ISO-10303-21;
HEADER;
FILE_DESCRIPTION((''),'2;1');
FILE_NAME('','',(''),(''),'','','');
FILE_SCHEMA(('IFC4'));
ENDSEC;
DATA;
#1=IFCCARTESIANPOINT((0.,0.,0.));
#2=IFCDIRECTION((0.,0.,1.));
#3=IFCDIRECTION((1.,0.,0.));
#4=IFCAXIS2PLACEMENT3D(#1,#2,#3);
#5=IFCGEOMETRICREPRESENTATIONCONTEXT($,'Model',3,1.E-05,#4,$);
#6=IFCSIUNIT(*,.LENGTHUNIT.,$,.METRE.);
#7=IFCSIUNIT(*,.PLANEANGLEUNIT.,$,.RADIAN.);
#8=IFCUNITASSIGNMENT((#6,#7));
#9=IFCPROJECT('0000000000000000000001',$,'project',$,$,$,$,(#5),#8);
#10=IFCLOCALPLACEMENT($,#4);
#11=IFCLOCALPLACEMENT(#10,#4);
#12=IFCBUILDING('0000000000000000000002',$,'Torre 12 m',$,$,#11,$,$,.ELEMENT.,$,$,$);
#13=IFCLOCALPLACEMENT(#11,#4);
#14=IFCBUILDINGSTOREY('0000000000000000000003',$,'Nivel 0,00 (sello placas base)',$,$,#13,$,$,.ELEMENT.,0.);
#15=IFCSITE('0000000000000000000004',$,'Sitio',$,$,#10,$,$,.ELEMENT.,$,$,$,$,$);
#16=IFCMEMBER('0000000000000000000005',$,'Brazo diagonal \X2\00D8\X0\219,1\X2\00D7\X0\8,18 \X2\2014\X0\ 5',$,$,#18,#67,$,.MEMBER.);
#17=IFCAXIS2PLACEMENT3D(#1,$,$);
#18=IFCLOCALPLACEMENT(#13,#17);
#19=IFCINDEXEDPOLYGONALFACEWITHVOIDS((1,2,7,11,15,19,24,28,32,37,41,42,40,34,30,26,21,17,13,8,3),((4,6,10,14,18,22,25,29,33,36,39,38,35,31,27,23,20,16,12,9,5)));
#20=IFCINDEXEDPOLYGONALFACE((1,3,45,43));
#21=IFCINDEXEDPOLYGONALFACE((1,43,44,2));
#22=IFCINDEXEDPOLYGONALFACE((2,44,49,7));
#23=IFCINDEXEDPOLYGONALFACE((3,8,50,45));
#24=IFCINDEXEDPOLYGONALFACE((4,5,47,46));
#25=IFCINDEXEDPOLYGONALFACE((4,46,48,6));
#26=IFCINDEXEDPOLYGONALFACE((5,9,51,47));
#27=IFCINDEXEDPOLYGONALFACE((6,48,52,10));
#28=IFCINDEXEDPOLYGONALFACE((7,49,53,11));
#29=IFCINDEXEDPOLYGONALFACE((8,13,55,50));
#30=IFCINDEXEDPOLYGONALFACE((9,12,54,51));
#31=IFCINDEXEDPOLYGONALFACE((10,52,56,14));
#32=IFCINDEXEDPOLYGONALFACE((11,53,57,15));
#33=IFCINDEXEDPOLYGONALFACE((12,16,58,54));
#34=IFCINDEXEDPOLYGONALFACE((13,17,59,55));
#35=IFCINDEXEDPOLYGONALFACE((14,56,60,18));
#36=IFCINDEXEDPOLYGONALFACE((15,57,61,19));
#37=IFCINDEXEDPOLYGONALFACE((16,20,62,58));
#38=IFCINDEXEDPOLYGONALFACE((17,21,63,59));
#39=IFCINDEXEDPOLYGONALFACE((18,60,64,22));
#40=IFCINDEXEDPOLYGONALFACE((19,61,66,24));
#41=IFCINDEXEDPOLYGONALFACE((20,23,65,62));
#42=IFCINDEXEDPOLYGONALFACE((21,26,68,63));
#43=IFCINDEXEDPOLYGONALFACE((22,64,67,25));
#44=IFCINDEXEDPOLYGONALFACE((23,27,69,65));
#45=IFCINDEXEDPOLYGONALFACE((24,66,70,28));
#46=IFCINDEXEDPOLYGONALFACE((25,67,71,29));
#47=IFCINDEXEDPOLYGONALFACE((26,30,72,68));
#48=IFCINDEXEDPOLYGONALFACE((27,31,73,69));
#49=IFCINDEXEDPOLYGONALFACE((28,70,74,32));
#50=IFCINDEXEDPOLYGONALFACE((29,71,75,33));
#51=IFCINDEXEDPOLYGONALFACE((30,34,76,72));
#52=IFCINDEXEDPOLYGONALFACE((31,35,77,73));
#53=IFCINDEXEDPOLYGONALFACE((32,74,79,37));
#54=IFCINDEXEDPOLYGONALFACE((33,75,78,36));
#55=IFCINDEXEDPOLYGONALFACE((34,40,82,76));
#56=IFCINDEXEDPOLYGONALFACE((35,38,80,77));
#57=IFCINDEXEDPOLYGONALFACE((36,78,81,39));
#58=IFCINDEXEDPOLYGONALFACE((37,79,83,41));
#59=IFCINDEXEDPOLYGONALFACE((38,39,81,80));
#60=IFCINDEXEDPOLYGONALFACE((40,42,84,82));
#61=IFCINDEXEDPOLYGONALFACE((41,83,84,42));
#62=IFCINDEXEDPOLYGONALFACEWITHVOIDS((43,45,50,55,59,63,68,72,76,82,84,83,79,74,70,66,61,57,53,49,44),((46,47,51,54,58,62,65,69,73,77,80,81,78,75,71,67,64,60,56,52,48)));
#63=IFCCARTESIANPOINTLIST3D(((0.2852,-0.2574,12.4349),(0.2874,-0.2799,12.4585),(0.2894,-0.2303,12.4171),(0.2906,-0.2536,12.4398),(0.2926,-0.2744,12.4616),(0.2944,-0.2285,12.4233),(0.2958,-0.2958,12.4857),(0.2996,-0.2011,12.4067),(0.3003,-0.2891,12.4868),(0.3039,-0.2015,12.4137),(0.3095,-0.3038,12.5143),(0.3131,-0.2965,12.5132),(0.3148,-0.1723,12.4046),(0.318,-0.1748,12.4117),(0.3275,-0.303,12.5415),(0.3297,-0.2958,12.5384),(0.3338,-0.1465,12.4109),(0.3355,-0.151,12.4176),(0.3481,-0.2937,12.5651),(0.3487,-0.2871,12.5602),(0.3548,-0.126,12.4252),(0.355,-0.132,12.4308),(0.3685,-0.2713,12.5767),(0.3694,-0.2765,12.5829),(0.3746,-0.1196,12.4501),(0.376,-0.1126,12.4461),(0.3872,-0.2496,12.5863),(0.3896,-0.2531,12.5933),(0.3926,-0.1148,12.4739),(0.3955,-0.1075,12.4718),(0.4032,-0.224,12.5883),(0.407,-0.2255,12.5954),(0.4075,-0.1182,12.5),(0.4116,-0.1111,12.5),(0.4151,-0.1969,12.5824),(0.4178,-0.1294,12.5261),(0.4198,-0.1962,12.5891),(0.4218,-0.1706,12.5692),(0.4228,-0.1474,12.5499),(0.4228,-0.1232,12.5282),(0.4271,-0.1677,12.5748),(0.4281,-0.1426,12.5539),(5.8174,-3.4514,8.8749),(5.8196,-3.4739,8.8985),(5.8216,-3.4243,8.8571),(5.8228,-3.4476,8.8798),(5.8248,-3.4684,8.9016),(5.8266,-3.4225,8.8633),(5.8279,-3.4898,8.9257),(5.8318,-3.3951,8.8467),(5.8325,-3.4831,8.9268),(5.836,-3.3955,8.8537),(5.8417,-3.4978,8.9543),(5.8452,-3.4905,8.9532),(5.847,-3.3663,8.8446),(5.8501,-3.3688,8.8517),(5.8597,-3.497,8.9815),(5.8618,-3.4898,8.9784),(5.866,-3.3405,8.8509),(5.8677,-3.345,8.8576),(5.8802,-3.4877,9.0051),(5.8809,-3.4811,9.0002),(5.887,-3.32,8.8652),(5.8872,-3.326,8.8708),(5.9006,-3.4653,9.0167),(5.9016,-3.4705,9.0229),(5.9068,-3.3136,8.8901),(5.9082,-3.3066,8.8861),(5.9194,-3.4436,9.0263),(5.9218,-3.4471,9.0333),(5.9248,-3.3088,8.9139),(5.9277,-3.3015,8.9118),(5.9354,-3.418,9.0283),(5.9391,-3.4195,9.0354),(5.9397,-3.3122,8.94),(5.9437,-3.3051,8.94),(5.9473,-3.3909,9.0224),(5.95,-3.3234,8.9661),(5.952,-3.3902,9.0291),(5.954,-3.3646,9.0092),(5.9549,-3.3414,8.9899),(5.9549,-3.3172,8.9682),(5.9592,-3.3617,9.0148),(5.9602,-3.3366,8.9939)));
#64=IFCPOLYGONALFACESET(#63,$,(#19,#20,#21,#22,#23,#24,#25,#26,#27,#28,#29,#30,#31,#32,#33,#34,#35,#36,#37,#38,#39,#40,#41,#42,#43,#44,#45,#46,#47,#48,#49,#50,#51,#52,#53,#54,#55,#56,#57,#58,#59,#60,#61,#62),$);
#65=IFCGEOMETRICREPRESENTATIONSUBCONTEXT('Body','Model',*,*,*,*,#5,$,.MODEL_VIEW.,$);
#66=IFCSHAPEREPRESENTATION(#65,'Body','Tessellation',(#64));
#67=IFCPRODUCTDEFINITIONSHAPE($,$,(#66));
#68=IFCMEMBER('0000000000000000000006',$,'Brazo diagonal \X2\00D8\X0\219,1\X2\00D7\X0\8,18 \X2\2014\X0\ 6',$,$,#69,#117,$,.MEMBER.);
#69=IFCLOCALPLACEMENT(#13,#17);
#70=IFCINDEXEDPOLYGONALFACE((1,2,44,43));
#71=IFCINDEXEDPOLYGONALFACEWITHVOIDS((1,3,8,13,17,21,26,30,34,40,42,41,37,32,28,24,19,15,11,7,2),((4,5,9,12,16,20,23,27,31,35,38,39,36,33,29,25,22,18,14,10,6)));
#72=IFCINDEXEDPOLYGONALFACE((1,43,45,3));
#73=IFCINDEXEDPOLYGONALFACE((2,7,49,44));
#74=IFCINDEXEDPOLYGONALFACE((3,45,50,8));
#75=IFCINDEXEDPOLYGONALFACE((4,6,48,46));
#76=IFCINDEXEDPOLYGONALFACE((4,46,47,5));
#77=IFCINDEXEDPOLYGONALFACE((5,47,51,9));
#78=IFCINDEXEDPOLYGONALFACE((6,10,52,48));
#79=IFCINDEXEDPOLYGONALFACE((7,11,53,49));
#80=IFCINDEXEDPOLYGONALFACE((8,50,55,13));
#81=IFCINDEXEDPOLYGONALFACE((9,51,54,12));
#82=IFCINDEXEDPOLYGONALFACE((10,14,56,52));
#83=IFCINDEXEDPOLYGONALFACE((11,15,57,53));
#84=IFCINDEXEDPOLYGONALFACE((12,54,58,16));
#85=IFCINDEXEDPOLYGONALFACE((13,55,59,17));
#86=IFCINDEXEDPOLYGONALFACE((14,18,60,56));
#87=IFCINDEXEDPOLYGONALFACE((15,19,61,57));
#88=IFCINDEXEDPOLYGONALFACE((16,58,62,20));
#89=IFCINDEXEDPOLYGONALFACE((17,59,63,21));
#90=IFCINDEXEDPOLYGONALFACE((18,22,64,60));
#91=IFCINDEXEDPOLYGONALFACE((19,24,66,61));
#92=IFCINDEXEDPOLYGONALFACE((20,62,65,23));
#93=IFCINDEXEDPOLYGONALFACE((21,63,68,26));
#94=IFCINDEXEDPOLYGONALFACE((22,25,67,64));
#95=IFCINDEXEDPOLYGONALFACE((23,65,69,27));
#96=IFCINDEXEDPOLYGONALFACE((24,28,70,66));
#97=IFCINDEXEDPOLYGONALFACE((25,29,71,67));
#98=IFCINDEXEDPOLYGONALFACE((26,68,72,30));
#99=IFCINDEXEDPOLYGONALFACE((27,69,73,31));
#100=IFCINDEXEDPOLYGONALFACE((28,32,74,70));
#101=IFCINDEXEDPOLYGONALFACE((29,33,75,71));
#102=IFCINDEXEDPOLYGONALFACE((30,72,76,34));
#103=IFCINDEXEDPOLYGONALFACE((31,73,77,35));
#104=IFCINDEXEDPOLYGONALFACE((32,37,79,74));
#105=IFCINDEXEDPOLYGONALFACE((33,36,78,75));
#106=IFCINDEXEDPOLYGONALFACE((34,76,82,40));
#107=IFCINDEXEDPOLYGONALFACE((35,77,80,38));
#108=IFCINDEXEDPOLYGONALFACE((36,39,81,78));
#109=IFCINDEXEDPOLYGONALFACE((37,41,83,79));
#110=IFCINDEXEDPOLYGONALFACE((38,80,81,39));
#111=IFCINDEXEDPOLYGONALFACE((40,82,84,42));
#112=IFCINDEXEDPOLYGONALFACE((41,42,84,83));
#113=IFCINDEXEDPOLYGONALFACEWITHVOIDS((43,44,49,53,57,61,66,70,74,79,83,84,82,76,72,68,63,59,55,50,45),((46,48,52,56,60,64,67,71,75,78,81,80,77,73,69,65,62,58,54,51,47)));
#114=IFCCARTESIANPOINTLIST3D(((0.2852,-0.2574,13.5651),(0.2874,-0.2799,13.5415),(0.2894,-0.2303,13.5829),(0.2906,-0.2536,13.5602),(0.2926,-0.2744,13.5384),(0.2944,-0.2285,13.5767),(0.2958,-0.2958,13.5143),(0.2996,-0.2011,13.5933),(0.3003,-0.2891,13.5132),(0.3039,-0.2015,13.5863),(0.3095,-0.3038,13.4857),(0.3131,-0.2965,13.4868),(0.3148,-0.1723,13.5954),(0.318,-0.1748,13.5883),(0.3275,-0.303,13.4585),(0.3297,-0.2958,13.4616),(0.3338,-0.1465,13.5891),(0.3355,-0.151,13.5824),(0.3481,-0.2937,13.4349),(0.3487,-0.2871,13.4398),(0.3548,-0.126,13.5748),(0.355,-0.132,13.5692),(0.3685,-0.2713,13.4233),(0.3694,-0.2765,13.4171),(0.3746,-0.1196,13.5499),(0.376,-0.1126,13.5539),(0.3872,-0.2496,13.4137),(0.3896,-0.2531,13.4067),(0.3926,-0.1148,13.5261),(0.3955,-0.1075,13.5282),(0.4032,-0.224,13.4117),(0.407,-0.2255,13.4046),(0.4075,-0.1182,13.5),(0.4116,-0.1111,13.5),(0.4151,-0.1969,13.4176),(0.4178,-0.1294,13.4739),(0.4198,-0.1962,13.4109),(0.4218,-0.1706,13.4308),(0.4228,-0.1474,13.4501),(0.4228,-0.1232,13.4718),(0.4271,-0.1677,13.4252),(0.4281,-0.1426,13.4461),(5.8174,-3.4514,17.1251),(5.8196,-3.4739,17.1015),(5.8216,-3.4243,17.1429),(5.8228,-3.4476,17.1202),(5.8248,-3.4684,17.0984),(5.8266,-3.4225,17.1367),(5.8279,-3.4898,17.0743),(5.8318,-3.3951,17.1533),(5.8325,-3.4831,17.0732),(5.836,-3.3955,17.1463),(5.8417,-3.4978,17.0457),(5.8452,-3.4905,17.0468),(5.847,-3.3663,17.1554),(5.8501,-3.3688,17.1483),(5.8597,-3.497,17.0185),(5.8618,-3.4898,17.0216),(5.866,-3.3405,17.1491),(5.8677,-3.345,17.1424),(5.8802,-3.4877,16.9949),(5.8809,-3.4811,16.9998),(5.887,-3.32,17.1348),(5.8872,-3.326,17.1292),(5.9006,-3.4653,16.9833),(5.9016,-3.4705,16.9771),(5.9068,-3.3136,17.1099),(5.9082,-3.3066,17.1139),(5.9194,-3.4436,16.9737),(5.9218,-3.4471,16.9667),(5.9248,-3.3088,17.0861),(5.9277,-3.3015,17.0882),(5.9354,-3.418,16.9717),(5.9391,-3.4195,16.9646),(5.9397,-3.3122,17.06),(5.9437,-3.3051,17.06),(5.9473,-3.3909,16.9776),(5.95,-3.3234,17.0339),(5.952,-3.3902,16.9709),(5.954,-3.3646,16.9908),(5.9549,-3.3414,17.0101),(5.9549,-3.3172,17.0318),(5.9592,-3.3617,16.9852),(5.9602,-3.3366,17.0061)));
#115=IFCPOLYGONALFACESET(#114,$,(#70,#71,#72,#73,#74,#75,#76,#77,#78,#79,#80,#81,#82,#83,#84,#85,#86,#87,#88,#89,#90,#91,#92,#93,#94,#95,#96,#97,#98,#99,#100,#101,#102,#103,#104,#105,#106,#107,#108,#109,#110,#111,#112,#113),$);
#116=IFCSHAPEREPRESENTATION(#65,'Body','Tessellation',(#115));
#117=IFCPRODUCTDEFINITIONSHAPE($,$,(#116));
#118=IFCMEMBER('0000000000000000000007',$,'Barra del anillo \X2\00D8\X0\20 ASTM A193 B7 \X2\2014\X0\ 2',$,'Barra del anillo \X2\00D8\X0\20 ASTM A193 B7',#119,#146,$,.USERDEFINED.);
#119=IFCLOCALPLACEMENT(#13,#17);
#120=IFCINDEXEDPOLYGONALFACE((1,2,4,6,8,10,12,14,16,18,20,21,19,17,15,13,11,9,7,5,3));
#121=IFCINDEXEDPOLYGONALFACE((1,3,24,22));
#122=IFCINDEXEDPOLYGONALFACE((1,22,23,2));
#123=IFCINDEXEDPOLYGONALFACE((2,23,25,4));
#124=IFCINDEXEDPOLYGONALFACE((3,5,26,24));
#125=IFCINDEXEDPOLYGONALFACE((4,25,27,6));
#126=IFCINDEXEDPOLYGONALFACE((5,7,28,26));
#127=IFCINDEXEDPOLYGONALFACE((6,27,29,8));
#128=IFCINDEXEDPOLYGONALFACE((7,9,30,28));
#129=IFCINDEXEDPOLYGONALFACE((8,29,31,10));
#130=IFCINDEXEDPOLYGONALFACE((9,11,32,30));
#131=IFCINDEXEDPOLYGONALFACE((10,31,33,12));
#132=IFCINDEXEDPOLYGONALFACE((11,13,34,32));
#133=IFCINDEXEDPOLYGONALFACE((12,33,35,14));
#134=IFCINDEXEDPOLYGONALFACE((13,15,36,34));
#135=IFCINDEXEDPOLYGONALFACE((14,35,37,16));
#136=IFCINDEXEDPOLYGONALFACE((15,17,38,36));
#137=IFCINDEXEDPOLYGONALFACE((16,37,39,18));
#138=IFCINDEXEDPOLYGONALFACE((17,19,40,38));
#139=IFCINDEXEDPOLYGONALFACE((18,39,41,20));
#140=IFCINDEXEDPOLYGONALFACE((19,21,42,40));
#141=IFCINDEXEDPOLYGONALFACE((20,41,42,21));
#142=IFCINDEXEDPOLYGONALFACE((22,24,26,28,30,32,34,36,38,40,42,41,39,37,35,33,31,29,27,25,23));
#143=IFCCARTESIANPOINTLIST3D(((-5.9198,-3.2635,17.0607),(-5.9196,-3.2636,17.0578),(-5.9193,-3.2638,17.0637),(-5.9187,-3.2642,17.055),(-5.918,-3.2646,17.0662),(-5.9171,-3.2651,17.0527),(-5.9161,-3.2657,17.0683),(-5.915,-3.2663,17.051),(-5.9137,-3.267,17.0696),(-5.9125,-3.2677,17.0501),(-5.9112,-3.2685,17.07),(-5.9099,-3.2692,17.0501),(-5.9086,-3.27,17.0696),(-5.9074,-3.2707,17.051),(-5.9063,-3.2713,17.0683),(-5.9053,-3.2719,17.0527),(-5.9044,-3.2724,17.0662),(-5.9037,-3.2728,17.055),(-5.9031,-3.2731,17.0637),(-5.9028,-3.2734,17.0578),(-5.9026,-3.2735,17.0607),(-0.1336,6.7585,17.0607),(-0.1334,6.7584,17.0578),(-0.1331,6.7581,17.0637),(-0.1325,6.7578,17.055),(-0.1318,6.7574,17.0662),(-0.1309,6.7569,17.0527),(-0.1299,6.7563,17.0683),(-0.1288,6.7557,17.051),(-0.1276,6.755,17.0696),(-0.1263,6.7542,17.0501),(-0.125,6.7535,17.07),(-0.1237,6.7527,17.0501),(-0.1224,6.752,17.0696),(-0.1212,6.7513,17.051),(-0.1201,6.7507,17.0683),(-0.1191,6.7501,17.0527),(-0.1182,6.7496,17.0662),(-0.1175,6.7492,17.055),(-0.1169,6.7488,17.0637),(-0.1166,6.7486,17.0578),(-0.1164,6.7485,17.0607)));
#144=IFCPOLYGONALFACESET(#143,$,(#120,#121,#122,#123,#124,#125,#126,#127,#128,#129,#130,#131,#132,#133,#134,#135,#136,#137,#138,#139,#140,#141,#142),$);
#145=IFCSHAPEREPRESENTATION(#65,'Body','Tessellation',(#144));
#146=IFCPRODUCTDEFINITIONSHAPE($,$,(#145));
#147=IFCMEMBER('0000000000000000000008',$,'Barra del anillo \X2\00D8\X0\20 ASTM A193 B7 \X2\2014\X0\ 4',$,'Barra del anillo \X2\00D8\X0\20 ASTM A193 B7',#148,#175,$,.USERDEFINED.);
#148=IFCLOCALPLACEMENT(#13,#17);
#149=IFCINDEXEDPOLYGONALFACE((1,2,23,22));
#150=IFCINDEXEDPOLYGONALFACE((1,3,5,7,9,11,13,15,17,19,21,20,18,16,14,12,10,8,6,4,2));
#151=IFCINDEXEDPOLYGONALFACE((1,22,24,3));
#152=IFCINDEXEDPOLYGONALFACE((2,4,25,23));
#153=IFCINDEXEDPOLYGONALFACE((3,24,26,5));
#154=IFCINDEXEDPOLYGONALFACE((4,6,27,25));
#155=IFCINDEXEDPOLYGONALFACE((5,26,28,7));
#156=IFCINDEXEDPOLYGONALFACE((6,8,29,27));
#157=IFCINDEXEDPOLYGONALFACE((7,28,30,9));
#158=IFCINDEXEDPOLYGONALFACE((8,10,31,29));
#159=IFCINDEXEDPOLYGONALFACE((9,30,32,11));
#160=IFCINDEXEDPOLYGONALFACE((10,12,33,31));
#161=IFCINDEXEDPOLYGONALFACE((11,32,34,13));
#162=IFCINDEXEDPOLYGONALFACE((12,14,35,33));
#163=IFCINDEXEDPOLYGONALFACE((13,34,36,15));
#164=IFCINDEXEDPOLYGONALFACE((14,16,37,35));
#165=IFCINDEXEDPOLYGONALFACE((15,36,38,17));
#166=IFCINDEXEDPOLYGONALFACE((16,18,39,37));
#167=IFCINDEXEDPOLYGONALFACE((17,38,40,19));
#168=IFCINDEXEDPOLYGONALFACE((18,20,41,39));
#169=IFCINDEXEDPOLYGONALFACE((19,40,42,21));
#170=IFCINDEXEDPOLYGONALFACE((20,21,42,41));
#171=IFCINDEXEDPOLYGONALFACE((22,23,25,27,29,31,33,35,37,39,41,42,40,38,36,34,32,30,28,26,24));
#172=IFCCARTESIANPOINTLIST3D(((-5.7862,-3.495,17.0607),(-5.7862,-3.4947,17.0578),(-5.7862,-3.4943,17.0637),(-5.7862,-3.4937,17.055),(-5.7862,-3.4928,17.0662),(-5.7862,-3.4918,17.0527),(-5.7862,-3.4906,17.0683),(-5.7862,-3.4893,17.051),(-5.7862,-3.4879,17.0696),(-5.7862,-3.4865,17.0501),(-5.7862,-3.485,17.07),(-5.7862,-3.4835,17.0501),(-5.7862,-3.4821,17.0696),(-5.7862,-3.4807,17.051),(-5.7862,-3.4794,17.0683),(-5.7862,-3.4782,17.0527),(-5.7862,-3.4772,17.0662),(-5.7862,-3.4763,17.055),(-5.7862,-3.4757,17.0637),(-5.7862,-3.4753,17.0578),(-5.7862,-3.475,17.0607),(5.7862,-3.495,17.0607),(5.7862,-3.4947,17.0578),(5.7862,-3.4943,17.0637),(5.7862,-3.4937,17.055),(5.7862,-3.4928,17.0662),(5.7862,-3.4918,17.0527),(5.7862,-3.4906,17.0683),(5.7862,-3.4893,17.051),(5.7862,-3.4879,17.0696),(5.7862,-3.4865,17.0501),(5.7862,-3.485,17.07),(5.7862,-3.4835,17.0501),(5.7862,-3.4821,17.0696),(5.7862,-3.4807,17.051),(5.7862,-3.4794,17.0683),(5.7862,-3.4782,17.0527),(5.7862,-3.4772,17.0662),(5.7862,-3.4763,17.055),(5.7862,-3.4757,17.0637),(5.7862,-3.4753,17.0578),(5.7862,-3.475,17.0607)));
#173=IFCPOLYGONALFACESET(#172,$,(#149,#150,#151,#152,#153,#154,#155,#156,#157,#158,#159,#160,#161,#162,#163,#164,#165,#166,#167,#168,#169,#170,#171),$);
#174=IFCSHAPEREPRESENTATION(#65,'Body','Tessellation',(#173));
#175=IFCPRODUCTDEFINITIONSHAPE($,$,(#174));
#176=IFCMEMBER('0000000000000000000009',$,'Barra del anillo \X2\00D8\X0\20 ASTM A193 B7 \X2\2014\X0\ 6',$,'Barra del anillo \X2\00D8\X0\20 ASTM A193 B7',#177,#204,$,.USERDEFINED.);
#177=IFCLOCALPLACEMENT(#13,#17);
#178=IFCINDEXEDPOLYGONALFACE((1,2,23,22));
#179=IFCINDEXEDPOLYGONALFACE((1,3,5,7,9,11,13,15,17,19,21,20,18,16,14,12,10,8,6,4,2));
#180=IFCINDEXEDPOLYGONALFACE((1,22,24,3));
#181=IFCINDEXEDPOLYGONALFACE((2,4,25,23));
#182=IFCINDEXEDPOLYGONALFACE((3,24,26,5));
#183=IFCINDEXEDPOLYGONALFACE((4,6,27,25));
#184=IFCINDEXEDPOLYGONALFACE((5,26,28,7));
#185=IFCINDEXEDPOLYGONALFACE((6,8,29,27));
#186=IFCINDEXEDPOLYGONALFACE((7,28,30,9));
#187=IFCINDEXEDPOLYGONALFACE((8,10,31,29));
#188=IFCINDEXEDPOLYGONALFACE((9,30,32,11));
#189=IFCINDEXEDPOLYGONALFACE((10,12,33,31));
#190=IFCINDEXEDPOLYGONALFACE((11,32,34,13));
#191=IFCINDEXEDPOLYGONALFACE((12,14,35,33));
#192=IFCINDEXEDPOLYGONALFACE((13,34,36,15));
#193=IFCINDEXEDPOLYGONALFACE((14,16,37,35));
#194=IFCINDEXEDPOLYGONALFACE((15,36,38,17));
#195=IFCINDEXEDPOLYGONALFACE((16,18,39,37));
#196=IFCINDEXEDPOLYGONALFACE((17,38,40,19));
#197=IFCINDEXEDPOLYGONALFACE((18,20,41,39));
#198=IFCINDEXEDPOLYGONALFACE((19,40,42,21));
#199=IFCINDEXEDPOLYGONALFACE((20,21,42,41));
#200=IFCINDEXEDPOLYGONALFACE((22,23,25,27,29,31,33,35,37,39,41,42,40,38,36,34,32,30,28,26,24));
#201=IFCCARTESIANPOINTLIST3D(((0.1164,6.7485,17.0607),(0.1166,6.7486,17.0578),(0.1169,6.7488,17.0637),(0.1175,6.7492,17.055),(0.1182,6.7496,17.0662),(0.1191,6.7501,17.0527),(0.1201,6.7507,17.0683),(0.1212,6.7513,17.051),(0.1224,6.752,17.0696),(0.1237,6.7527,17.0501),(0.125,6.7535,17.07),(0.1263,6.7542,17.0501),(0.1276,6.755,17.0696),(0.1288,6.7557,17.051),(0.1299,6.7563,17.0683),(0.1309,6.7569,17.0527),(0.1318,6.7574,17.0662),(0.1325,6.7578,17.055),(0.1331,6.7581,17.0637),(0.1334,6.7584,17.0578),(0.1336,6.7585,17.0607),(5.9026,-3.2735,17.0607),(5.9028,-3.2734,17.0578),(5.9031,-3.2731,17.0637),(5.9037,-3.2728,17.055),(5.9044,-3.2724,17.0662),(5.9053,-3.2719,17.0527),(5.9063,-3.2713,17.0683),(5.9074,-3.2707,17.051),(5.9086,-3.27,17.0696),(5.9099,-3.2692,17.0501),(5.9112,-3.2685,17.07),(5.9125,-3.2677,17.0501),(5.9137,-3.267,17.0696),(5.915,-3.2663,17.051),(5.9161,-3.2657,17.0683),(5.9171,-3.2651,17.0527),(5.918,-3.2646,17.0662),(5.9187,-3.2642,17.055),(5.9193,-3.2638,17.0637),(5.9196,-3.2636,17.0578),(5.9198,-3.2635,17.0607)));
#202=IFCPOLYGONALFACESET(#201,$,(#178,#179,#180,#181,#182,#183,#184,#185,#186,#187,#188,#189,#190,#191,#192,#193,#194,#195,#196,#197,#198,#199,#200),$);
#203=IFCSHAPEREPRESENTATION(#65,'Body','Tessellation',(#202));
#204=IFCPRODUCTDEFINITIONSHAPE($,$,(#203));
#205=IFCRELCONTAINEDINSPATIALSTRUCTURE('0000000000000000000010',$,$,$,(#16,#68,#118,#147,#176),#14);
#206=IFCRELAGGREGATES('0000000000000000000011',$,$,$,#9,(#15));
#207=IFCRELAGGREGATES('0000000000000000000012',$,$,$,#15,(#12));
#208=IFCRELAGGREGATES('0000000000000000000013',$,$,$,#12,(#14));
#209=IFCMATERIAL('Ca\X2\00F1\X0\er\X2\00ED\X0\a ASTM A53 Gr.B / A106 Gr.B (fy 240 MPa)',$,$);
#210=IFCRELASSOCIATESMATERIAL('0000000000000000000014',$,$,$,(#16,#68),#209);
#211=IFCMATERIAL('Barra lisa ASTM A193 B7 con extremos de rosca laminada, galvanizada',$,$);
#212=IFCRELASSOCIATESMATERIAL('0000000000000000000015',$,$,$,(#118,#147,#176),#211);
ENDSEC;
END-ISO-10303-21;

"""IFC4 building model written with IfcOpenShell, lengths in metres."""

from ifc_helpers import new_model, si_unit, frame, origin, origin_with_axes, origin_2d, place, context, subcontext, project, spatial, circle, hollow_circle, extrude, material, element, save


model = new_model("IFC4")

# Units and contexts
model_context = context("Model", 3, precision=1e-05, world=origin_with_axes())
body_context = subcontext(model_context, "Body", "Model", "MODEL_VIEW")
ifc_project = project(units=[si_unit("LENGTHUNIT", "METRE"), si_unit("PLANEANGLEUNIT", "RADIAN")], contexts=[model_context])

# Site, building, storey
site_placement = place(None, origin_with_axes())
site = spatial("IfcSite", under=ifc_project, at=site_placement, Name="Sitio", CompositionType="ELEMENT")
building_placement = place(site_placement, origin_with_axes())
building = spatial("IfcBuilding", under=site, at=building_placement, Name="Torre 12 m", CompositionType="ELEMENT")
storey_placement = place(building_placement, origin_with_axes())
storey = spatial("IfcBuildingStorey", under=building, at=storey_placement, Name="Nivel 0,00 (sello placas base)", CompositionType="ELEMENT", Elevation=0.0)

# Members
ifc_material_1 = material(Name="Cañería ASTM A53 Gr.B / A106 Gr.B (fy 240 MPa)")
for number, where, z_axis, x_axis, name in (
    (1, (0.3568, -0.206, 12.5), (0.756483, -0.436756, -0.486804), (0.5, 0.866025, 0.0), "Brazo diagonal Ø219,1×8,18 — 5"),
    (2, (0.3568, -0.206, 13.5), (0.756483, -0.436756, 0.486804), (0.5, 0.866025, 0.0), "Brazo diagonal Ø219,1×8,18 — 6"),
):
    element("IfcMember", number, at=place(storey_placement, frame(where, z_axis=z_axis, x_axis=x_axis)), inside=storey, material=ifc_material_1, Name=name, PredefinedType="MEMBER", context=body_context, shape_type="SweptSolid", body=[
        extrude(hollow_circle(Radius=0.1095, WallThickness=0.0082, at=origin_2d()), origin(), (0.0, 0.0, 1.0), 7.313),
    ])
ifc_material_2 = material(Name="Barra lisa ASTM A193 B7 con extremos de rosca laminada, galvanizada")
for number, where, z_axis, x_axis, name in (
    (3, (-0.125, 6.7535, 17.06), (-0.5, -0.866025, 0.0), (0.0, 0.0, 1.0), "Barra del anillo Ø20 ASTM A193 B7 — 2"),
    (4, (-5.7862, -3.485, 17.06), (1.0, 0.0, 0.0), (0.0, 0.0, 1.0), "Barra del anillo Ø20 ASTM A193 B7 — 4"),
    (5, (5.9112, -3.2685, 17.06), (-0.5, 0.866025, 0.0), (0.0, 0.0, 1.0), "Barra del anillo Ø20 ASTM A193 B7 — 6"),
):
    element("IfcMember", number, at=place(storey_placement, frame(where, z_axis=z_axis, x_axis=x_axis)), inside=storey, material=ifc_material_2, Name=name, ObjectType="Barra del anillo Ø20 ASTM A193 B7", PredefinedType="USERDEFINED", context=body_context, shape_type="SweptSolid", body=[
        extrude(circle(Radius=0.01, at=origin_2d()), origin(), (0.0, 0.0, 1.0), 11.5724),
    ])

save(model, "model.ifc")
